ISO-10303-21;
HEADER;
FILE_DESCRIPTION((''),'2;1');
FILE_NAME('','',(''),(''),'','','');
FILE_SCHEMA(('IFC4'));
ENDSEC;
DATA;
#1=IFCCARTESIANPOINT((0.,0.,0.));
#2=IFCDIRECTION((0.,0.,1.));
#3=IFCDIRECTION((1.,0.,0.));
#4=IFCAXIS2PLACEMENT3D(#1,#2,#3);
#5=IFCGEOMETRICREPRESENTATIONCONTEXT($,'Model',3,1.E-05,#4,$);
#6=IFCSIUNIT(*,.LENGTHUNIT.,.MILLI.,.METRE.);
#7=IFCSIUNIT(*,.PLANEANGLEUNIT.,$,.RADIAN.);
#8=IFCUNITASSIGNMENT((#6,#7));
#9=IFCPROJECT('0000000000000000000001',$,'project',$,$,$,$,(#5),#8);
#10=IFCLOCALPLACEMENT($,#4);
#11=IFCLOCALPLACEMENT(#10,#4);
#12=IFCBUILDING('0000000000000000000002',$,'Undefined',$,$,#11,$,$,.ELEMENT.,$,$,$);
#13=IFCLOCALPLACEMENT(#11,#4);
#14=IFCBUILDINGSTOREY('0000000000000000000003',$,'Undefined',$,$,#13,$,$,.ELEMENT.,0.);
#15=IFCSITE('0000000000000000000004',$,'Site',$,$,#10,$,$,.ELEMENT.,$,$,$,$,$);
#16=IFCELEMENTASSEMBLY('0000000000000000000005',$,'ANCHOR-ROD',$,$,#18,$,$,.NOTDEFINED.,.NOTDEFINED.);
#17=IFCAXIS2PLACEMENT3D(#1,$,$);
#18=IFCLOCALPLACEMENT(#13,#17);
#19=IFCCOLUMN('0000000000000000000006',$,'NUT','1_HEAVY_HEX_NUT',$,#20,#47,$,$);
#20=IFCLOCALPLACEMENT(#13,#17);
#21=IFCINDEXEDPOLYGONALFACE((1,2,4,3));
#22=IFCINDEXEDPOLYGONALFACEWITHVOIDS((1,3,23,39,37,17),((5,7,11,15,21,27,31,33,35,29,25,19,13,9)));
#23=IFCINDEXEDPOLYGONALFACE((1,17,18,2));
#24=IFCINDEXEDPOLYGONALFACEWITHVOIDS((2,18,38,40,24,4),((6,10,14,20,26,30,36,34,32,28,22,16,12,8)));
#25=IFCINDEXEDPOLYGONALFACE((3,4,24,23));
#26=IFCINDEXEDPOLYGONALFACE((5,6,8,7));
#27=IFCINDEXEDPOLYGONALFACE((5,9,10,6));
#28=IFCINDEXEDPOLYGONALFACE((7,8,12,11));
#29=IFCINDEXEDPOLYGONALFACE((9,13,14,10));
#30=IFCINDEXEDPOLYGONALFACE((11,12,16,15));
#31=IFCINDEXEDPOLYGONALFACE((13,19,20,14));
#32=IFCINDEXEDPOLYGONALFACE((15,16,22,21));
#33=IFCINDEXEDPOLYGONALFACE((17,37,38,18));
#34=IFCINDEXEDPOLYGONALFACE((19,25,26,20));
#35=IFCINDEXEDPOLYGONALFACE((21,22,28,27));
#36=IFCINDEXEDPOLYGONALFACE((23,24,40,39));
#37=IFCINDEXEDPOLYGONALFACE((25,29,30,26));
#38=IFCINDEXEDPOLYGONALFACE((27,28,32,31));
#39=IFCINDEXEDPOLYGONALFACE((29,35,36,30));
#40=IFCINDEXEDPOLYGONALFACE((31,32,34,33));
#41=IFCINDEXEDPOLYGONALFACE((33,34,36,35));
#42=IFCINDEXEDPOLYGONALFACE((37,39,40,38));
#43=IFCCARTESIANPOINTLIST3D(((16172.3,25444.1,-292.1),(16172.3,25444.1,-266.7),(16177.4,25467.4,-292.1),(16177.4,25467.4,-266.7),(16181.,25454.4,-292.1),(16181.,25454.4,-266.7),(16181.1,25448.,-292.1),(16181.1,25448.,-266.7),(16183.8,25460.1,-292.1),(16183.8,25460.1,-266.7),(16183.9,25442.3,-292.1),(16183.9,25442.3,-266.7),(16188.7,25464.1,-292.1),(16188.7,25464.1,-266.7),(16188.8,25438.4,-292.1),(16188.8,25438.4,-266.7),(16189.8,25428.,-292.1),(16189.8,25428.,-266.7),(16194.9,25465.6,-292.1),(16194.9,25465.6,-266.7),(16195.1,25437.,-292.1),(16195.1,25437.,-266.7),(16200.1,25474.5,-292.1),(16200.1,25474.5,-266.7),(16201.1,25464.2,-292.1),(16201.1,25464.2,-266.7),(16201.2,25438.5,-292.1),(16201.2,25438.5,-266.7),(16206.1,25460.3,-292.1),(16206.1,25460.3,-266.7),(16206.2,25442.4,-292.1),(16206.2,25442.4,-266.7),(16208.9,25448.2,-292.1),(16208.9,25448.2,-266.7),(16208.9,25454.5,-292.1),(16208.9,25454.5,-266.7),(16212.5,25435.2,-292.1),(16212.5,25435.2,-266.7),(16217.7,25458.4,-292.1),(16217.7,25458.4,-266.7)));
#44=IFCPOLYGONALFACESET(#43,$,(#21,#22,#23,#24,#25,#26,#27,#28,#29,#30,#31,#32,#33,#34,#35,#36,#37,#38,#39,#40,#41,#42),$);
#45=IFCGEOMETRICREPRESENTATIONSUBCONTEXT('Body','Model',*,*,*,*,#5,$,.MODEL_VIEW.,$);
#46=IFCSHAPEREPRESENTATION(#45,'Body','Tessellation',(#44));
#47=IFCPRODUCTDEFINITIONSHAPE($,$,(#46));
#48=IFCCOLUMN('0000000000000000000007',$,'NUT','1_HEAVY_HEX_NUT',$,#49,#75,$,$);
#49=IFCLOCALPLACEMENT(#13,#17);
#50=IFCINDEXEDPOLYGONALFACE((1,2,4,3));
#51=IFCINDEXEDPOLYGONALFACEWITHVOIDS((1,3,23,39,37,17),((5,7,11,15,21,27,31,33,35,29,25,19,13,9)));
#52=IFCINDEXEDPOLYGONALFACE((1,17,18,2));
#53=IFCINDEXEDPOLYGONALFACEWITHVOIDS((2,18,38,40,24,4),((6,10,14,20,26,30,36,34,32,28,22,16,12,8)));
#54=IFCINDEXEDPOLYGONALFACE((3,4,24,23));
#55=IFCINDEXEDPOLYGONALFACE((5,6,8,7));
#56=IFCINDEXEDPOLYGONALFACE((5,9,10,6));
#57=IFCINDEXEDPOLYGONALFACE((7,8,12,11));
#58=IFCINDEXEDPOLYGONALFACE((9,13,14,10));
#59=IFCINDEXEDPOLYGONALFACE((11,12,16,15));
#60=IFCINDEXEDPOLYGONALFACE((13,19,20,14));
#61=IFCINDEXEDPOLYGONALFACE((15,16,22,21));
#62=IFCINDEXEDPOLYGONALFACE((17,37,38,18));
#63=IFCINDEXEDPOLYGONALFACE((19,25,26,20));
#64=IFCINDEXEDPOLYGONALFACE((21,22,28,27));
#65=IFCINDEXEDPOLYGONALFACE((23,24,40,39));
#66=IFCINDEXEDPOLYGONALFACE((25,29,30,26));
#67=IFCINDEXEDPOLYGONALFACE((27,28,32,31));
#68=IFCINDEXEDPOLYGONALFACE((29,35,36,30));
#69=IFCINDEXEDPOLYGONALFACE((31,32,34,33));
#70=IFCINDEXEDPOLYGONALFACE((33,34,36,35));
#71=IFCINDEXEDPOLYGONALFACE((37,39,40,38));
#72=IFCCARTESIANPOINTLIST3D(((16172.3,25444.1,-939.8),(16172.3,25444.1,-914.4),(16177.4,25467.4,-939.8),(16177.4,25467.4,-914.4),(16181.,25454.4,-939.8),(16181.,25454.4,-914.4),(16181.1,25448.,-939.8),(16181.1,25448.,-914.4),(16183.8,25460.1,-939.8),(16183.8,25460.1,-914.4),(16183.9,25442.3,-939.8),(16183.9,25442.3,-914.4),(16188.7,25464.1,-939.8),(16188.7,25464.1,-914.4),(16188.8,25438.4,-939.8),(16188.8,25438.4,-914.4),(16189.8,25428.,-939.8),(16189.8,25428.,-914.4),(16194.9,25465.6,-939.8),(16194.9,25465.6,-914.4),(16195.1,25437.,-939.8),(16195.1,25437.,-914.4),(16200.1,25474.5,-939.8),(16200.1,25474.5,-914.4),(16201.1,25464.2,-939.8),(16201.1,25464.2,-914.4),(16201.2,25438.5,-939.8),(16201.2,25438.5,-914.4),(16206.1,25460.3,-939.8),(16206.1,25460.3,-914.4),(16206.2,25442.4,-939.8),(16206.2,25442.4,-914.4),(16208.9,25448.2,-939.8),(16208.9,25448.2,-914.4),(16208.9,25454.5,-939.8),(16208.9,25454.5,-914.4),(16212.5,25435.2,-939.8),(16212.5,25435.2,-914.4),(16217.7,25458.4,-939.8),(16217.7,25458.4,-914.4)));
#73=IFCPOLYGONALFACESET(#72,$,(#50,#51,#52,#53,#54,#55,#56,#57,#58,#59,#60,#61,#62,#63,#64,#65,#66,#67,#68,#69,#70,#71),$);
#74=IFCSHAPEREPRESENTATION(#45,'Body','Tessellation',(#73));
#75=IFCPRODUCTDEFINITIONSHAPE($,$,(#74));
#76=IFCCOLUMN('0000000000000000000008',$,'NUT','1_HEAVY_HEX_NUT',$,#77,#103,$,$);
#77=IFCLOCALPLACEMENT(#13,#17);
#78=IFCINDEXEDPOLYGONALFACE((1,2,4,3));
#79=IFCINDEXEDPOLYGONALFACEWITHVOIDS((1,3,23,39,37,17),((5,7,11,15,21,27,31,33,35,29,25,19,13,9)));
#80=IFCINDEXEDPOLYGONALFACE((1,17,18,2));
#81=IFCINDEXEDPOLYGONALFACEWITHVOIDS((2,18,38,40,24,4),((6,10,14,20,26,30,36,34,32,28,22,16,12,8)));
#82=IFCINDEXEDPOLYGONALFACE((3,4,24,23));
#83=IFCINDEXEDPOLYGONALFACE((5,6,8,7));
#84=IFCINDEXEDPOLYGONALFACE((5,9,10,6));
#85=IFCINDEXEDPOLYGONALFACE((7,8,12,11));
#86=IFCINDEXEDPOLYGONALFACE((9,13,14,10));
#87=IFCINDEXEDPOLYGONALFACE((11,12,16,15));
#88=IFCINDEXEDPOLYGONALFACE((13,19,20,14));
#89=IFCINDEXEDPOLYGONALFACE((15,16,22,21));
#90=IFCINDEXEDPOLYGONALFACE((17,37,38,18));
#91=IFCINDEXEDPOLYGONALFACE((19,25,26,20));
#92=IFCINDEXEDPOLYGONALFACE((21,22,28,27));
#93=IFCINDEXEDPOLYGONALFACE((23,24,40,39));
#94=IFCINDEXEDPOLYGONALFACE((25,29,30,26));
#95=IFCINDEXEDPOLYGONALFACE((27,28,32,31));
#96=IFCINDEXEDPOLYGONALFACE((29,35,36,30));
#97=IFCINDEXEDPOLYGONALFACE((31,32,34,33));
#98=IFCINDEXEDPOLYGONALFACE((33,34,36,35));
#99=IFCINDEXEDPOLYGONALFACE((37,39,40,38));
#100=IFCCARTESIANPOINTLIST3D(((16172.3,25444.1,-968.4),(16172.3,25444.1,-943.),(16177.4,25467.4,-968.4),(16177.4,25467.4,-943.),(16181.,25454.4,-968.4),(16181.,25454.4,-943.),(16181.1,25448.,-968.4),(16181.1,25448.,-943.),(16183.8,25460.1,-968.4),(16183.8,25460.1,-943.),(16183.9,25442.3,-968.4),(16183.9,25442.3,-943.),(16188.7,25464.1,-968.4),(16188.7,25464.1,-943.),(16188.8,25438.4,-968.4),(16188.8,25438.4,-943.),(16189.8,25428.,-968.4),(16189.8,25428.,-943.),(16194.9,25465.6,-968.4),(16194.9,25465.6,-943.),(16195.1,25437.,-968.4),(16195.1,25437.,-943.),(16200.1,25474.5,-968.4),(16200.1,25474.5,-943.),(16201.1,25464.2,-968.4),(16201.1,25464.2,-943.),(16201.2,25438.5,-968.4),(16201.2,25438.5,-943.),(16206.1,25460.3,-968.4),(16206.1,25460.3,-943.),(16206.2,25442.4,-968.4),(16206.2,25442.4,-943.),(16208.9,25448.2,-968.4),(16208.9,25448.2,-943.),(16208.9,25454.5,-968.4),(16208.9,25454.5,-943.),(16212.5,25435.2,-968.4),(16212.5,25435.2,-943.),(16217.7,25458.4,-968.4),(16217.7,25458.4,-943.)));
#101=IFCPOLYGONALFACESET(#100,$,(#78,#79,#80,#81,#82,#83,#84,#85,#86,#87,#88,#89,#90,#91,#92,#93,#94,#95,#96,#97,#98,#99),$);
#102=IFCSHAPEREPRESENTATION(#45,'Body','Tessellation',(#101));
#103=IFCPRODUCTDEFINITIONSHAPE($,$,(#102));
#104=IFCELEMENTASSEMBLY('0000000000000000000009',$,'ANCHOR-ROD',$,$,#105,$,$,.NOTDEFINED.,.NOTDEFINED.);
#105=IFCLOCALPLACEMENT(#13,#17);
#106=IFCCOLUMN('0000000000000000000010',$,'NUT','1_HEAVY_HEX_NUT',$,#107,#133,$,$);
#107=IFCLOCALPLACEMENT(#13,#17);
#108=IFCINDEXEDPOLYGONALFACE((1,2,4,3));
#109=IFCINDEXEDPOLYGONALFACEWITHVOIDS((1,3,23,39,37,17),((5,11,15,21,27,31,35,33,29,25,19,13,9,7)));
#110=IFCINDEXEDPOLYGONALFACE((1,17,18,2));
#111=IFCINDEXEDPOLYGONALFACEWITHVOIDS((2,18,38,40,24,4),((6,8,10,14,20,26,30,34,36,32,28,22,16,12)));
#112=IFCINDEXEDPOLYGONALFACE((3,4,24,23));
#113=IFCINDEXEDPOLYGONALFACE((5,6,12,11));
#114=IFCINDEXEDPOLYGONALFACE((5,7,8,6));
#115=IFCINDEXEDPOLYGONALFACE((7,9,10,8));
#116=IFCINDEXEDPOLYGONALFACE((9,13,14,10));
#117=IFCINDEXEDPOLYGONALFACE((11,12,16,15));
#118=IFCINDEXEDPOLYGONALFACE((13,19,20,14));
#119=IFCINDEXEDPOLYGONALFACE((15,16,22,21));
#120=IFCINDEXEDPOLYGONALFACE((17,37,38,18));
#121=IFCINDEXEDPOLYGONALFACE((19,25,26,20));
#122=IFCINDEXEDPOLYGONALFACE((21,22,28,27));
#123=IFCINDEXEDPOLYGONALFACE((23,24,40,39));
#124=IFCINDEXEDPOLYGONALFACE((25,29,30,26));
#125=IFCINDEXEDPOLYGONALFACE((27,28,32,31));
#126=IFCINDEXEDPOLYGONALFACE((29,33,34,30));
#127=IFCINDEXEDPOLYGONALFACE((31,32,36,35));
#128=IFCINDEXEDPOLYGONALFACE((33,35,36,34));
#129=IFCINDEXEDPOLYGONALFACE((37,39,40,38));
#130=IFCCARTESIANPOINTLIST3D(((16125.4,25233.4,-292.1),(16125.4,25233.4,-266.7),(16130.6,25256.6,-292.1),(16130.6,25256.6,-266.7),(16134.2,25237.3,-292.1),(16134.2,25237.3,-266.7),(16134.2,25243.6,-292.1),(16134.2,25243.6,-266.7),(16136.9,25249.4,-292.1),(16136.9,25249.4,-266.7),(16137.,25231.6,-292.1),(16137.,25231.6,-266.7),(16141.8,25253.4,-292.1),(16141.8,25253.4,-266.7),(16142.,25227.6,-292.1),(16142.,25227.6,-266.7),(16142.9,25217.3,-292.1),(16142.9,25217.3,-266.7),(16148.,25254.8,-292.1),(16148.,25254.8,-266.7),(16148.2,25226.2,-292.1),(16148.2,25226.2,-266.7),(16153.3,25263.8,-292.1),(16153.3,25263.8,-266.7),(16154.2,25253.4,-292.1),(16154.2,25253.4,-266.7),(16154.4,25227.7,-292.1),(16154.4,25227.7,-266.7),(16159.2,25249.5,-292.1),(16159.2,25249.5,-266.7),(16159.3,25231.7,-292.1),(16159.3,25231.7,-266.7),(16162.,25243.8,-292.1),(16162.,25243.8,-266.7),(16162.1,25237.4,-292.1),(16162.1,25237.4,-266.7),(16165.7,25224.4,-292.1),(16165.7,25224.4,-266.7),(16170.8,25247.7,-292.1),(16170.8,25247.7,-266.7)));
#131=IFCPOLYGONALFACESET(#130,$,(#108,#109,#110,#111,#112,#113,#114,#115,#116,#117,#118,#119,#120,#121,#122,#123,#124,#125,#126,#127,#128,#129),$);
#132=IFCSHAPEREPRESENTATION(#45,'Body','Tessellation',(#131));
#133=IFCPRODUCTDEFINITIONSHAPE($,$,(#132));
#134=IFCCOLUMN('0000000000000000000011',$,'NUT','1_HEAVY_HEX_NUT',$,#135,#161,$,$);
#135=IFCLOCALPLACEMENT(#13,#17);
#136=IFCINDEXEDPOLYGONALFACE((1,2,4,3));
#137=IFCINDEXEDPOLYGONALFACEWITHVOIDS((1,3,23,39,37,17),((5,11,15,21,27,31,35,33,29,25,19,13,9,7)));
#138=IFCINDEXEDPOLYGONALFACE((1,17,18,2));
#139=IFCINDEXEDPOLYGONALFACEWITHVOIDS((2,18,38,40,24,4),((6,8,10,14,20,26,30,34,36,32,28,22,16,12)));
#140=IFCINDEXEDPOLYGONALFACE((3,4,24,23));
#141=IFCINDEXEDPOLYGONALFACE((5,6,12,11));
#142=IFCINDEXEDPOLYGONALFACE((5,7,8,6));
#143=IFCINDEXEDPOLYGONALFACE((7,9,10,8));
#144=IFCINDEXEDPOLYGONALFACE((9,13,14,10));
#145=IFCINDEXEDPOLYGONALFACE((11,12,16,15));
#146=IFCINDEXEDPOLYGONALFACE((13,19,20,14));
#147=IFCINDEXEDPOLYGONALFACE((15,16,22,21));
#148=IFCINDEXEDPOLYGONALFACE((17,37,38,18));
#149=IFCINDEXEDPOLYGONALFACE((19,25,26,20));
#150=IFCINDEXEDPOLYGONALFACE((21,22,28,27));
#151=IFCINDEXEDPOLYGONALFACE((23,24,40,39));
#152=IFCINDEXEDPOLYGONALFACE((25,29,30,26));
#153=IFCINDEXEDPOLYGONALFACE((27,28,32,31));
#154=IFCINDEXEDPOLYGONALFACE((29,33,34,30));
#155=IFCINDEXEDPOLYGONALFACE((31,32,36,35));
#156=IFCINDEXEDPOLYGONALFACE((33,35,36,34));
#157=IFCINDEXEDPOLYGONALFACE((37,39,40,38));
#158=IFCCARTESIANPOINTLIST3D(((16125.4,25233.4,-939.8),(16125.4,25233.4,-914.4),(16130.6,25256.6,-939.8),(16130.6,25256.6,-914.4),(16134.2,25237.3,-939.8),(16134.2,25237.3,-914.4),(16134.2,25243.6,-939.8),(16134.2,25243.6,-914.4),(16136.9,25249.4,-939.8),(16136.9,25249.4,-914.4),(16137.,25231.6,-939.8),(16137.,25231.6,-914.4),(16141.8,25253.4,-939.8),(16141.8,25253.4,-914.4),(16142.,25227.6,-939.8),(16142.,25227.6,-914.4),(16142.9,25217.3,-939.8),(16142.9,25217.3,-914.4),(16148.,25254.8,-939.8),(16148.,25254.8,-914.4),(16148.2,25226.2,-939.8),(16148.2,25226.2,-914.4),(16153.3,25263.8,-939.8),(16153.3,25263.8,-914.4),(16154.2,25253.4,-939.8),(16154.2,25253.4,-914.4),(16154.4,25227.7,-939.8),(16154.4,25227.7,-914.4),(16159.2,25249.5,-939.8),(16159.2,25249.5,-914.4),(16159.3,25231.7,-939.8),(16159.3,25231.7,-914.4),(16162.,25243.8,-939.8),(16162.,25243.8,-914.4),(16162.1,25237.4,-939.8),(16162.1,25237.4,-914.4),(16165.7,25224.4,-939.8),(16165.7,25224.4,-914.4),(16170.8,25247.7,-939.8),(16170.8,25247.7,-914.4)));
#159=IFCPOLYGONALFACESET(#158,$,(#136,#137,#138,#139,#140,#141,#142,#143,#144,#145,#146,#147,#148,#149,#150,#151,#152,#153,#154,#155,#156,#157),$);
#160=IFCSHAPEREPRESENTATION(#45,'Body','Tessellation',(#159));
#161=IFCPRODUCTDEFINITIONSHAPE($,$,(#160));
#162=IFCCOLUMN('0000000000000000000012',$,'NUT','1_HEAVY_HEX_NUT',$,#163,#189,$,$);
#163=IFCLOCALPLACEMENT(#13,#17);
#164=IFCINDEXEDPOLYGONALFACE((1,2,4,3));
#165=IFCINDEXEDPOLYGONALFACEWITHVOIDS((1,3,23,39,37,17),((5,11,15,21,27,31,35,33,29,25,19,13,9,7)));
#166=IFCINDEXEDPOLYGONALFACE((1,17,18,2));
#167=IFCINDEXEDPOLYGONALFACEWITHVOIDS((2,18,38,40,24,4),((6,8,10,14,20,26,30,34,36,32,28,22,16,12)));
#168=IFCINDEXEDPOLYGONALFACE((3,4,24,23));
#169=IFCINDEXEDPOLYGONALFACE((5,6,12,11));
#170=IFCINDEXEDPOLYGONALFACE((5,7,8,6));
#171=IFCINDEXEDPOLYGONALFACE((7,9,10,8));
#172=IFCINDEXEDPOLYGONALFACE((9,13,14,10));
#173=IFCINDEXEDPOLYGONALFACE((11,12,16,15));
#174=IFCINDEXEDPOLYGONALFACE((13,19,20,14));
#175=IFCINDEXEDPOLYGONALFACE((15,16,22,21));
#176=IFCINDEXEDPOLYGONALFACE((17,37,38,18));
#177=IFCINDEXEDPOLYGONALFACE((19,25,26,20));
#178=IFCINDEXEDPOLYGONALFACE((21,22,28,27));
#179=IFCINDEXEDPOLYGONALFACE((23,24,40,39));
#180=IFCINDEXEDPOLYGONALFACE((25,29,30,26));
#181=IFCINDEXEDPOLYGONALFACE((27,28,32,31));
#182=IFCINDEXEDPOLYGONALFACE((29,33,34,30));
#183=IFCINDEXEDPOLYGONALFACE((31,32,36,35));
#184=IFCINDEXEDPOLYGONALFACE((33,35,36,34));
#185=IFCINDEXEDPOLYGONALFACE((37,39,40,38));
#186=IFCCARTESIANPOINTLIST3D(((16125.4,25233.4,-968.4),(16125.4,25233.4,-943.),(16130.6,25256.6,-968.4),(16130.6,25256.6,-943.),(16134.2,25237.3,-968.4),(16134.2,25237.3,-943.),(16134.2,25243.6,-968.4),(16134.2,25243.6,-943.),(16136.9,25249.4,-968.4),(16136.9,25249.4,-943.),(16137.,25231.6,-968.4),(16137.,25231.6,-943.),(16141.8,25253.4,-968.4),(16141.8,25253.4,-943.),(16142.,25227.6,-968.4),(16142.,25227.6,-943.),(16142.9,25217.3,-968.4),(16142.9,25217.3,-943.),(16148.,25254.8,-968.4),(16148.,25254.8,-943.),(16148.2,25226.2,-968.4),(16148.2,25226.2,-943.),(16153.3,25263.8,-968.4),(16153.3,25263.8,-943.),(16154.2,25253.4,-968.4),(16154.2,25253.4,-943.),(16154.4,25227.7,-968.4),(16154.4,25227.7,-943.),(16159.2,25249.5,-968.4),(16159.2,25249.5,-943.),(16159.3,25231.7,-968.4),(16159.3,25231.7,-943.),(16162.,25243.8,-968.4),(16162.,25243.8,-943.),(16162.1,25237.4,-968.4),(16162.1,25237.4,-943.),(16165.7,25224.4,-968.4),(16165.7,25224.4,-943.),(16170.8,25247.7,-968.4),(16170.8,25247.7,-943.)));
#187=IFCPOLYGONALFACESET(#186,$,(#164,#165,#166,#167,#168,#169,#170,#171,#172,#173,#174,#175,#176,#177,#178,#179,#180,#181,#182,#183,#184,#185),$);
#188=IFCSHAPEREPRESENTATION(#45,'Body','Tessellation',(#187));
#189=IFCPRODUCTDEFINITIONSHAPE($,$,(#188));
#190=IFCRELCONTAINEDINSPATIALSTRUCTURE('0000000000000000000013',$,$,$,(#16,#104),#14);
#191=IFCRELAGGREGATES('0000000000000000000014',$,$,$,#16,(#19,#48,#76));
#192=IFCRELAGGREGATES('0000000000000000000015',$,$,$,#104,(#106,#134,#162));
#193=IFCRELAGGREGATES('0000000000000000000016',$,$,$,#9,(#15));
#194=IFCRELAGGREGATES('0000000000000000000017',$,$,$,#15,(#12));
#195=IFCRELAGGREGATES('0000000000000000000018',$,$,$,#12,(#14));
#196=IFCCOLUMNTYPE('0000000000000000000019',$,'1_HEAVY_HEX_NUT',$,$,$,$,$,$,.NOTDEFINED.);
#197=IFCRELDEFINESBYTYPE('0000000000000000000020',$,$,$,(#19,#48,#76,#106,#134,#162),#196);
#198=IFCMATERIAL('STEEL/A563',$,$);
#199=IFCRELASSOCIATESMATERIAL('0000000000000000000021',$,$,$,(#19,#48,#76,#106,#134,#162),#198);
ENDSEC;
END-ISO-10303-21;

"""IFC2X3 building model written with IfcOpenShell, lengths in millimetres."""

from ifc_helpers import new_model, si_unit, frame, origin_with_axes, place, context, subcontext, project, spatial, polyline, outline, extrude, material, type_object, element, aggregate, save


model = new_model("IFC2X3")

# Units and contexts
model_context = context("Model", 3, precision=1e-05, world=origin_with_axes())
body_context = subcontext(model_context, "Body", "Model", "MODEL_VIEW")
ifc_project = project(units=[si_unit("LENGTHUNIT", "METRE", prefix="MILLI"), si_unit("PLANEANGLEUNIT", "RADIAN")], contexts=[model_context])

# Site, building, storey
site_placement = place(None, origin_with_axes())
site = spatial("IfcSite", under=ifc_project, at=site_placement, Name="Site", CompositionType="ELEMENT")
building_placement = place(site_placement, origin_with_axes())
building = spatial("IfcBuilding", under=site, at=building_placement, Name="Undefined", CompositionType="ELEMENT")
storey_placement = place(building_placement, origin_with_axes())
storey = spatial("IfcBuildingStorey", under=building, at=storey_placement, Name="Undefined", CompositionType="ELEMENT", Elevation=0.0)

# Element assemblies, columns
assembly_1_placement = place(storey_placement, origin_with_axes())
assembly_1 = element("IfcElementAssembly", 1, at=assembly_1_placement, inside=storey, Name="ANCHOR-ROD", AssemblyPlace="NOTDEFINED", PredefinedType="NOTDEFINED")
ifc_material_1 = material(Name="STEEL/A563")
column_type_1 = type_object("IfcColumnType", Name="1_HEAVY_HEX_NUT", PredefinedType="NOTDEFINED")
column_1_placement = place(assembly_1_placement, frame((16195.0, 25451.3, -266.7), z_axis=(0.0, 0.0, -1.0), x_axis=(-0.976162, 0.217044, 0.0)))
column_1 = element("IfcColumn", 2, at=column_1_placement, type_object=column_type_1, material=ifc_material_1, Name="NUT", Description="1_HEAVY_HEX_NUT", context=body_context, shape_type="SweptSolid", body=[
    extrude(outline(polyline([(-11.9, -20.6), (-23.8, 0.0), (-11.9, 20.6), (11.9, 20.6), (23.8, 0.0), (11.9, -20.6), (-11.9, -20.6)]), holes=[polyline([(11.2, 8.9), (6.2, 12.9), (0.0, 14.3), (-6.2, 12.9), (-11.2, 8.9), (-13.9, 3.2), (-13.9, -3.2), (-11.2, -8.9), (-6.2, -12.9), (0.0, -14.3), (6.2, -12.9), (11.2, -8.9), (13.9, -3.2), (13.9, 3.2), (11.2, 8.9)])]), frame((0.0, 0.0, 25.4), z_axis=(0.0, 0.0, -1.0), x_axis=(0.0, 1.0, 0.0)), (0.0, 0.0, 1.0), 25.4),
])
column_2_placement = place(assembly_1_placement, frame((16195.0, 25451.3, -914.4), z_axis=(0.0, 0.0, -1.0), x_axis=(-0.976162, 0.217044, 0.0)))
column_2 = element("IfcColumn", 3, at=column_2_placement, type_object=column_type_1, material=ifc_material_1, Name="NUT", Description="1_HEAVY_HEX_NUT", context=body_context, shape_type="SweptSolid", body=[
    extrude(outline(polyline([(-11.9, -20.6), (-23.8, 0.0), (-11.9, 20.6), (11.9, 20.6), (23.8, 0.0), (11.9, -20.6), (-11.9, -20.6)]), holes=[polyline([(11.2, 8.9), (6.2, 12.9), (0.0, 14.3), (-6.2, 12.9), (-11.2, 8.9), (-13.9, 3.2), (-13.9, -3.2), (-11.2, -8.9), (-6.2, -12.9), (0.0, -14.3), (6.2, -12.9), (11.2, -8.9), (13.9, -3.2), (13.9, 3.2), (11.2, 8.9)])]), frame((0.0, 0.0, 25.4), z_axis=(0.0, 0.0, -1.0), x_axis=(0.0, 1.0, 0.0)), (0.0, 0.0, 1.0), 25.4),
])
column_3_placement = place(assembly_1_placement, frame((16195.0, 25451.3, -943.0), z_axis=(0.0, 0.0, -1.0), x_axis=(-0.976162, 0.217044, 0.0)))
column_3 = element("IfcColumn", 4, at=column_3_placement, type_object=column_type_1, material=ifc_material_1, Name="NUT", Description="1_HEAVY_HEX_NUT", context=body_context, shape_type="SweptSolid", body=[
    extrude(outline(polyline([(-11.9, -20.6), (-23.8, 0.0), (-11.9, 20.6), (11.9, 20.6), (23.8, 0.0), (11.9, -20.6), (-11.9, -20.6)]), holes=[polyline([(11.2, 8.9), (6.2, 12.9), (0.0, 14.3), (-6.2, 12.9), (-11.2, 8.9), (-13.9, 3.2), (-13.9, -3.2), (-11.2, -8.9), (-6.2, -12.9), (0.0, -14.3), (6.2, -12.9), (11.2, -8.9), (13.9, -3.2), (13.9, 3.2), (11.2, 8.9)])]), frame((0.0, 0.0, 25.4), z_axis=(0.0, 0.0, -1.0), x_axis=(0.0, 1.0, 0.0)), (0.0, 0.0, 1.0), 25.4),
])
aggregate(assembly_1, [column_1, column_2, column_3])
assembly_2_placement = place(storey_placement, origin_with_axes())
assembly_2 = element("IfcElementAssembly", 5, at=assembly_2_placement, inside=storey, Name="ANCHOR-ROD", AssemblyPlace="NOTDEFINED", PredefinedType="NOTDEFINED")
column_4_placement = place(assembly_2_placement, frame((16148.1, 25240.5, -266.7), z_axis=(0.0, 0.0, -1.0), x_axis=(0.976162, -0.217044, 0.0)))
column_4 = element("IfcColumn", 6, at=column_4_placement, type_object=column_type_1, material=ifc_material_1, Name="NUT", Description="1_HEAVY_HEX_NUT", context=body_context, shape_type="SweptSolid", body=[
    extrude(outline(polyline([(-11.9, -20.6), (-23.8, 0.0), (-11.9, 20.6), (11.9, 20.6), (23.8, 0.0), (11.9, -20.6), (-11.9, -20.6)]), holes=[polyline([(11.2, 8.9), (6.2, 12.9), (0.0, 14.3), (-6.2, 12.9), (-11.2, 8.9), (-13.9, 3.2), (-13.9, -3.2), (-11.2, -8.9), (-6.2, -12.9), (0.0, -14.3), (6.2, -12.9), (11.2, -8.9), (13.9, -3.2), (13.9, 3.2), (11.2, 8.9)])]), frame((0.0, 0.0, 25.4), z_axis=(0.0, 0.0, -1.0), x_axis=(0.0, 1.0, 0.0)), (0.0, 0.0, 1.0), 25.4),
])
column_5_placement = place(assembly_2_placement, frame((16148.1, 25240.5, -914.4), z_axis=(0.0, 0.0, -1.0), x_axis=(0.976162, -0.217044, 0.0)))
column_5 = element("IfcColumn", 7, at=column_5_placement, type_object=column_type_1, material=ifc_material_1, Name="NUT", Description="1_HEAVY_HEX_NUT", context=body_context, shape_type="SweptSolid", body=[
    extrude(outline(polyline([(-11.9, -20.6), (-23.8, 0.0), (-11.9, 20.6), (11.9, 20.6), (23.8, 0.0), (11.9, -20.6), (-11.9, -20.6)]), holes=[polyline([(11.2, 8.9), (6.2, 12.9), (0.0, 14.3), (-6.2, 12.9), (-11.2, 8.9), (-13.9, 3.2), (-13.9, -3.2), (-11.2, -8.9), (-6.2, -12.9), (0.0, -14.3), (6.2, -12.9), (11.2, -8.9), (13.9, -3.2), (13.9, 3.2), (11.2, 8.9)])]), frame((0.0, 0.0, 25.4), z_axis=(0.0, 0.0, -1.0), x_axis=(0.0, 1.0, 0.0)), (0.0, 0.0, 1.0), 25.4),
])
column_6_placement = place(assembly_2_placement, frame((16148.1, 25240.5, -943.0), z_axis=(0.0, 0.0, -1.0), x_axis=(0.976162, -0.217044, 0.0)))
column_6 = element("IfcColumn", 8, at=column_6_placement, type_object=column_type_1, material=ifc_material_1, Name="NUT", Description="1_HEAVY_HEX_NUT", context=body_context, shape_type="SweptSolid", body=[
    extrude(outline(polyline([(-11.9, -20.6), (-23.8, 0.0), (-11.9, 20.6), (11.9, 20.6), (23.8, 0.0), (11.9, -20.6), (-11.9, -20.6)]), holes=[polyline([(11.2, 8.9), (6.2, 12.9), (0.0, 14.3), (-6.2, 12.9), (-11.2, 8.9), (-13.9, 3.2), (-13.9, -3.2), (-11.2, -8.9), (-6.2, -12.9), (0.0, -14.3), (6.2, -12.9), (11.2, -8.9), (13.9, -3.2), (13.9, 3.2), (11.2, 8.9)])]), frame((0.0, 0.0, 25.4), z_axis=(0.0, 0.0, -1.0), x_axis=(0.0, 1.0, 0.0)), (0.0, 0.0, 1.0), 25.4),
])

aggregate(assembly_2, [column_4, column_5, column_6])

save(model, "model.ifc")
